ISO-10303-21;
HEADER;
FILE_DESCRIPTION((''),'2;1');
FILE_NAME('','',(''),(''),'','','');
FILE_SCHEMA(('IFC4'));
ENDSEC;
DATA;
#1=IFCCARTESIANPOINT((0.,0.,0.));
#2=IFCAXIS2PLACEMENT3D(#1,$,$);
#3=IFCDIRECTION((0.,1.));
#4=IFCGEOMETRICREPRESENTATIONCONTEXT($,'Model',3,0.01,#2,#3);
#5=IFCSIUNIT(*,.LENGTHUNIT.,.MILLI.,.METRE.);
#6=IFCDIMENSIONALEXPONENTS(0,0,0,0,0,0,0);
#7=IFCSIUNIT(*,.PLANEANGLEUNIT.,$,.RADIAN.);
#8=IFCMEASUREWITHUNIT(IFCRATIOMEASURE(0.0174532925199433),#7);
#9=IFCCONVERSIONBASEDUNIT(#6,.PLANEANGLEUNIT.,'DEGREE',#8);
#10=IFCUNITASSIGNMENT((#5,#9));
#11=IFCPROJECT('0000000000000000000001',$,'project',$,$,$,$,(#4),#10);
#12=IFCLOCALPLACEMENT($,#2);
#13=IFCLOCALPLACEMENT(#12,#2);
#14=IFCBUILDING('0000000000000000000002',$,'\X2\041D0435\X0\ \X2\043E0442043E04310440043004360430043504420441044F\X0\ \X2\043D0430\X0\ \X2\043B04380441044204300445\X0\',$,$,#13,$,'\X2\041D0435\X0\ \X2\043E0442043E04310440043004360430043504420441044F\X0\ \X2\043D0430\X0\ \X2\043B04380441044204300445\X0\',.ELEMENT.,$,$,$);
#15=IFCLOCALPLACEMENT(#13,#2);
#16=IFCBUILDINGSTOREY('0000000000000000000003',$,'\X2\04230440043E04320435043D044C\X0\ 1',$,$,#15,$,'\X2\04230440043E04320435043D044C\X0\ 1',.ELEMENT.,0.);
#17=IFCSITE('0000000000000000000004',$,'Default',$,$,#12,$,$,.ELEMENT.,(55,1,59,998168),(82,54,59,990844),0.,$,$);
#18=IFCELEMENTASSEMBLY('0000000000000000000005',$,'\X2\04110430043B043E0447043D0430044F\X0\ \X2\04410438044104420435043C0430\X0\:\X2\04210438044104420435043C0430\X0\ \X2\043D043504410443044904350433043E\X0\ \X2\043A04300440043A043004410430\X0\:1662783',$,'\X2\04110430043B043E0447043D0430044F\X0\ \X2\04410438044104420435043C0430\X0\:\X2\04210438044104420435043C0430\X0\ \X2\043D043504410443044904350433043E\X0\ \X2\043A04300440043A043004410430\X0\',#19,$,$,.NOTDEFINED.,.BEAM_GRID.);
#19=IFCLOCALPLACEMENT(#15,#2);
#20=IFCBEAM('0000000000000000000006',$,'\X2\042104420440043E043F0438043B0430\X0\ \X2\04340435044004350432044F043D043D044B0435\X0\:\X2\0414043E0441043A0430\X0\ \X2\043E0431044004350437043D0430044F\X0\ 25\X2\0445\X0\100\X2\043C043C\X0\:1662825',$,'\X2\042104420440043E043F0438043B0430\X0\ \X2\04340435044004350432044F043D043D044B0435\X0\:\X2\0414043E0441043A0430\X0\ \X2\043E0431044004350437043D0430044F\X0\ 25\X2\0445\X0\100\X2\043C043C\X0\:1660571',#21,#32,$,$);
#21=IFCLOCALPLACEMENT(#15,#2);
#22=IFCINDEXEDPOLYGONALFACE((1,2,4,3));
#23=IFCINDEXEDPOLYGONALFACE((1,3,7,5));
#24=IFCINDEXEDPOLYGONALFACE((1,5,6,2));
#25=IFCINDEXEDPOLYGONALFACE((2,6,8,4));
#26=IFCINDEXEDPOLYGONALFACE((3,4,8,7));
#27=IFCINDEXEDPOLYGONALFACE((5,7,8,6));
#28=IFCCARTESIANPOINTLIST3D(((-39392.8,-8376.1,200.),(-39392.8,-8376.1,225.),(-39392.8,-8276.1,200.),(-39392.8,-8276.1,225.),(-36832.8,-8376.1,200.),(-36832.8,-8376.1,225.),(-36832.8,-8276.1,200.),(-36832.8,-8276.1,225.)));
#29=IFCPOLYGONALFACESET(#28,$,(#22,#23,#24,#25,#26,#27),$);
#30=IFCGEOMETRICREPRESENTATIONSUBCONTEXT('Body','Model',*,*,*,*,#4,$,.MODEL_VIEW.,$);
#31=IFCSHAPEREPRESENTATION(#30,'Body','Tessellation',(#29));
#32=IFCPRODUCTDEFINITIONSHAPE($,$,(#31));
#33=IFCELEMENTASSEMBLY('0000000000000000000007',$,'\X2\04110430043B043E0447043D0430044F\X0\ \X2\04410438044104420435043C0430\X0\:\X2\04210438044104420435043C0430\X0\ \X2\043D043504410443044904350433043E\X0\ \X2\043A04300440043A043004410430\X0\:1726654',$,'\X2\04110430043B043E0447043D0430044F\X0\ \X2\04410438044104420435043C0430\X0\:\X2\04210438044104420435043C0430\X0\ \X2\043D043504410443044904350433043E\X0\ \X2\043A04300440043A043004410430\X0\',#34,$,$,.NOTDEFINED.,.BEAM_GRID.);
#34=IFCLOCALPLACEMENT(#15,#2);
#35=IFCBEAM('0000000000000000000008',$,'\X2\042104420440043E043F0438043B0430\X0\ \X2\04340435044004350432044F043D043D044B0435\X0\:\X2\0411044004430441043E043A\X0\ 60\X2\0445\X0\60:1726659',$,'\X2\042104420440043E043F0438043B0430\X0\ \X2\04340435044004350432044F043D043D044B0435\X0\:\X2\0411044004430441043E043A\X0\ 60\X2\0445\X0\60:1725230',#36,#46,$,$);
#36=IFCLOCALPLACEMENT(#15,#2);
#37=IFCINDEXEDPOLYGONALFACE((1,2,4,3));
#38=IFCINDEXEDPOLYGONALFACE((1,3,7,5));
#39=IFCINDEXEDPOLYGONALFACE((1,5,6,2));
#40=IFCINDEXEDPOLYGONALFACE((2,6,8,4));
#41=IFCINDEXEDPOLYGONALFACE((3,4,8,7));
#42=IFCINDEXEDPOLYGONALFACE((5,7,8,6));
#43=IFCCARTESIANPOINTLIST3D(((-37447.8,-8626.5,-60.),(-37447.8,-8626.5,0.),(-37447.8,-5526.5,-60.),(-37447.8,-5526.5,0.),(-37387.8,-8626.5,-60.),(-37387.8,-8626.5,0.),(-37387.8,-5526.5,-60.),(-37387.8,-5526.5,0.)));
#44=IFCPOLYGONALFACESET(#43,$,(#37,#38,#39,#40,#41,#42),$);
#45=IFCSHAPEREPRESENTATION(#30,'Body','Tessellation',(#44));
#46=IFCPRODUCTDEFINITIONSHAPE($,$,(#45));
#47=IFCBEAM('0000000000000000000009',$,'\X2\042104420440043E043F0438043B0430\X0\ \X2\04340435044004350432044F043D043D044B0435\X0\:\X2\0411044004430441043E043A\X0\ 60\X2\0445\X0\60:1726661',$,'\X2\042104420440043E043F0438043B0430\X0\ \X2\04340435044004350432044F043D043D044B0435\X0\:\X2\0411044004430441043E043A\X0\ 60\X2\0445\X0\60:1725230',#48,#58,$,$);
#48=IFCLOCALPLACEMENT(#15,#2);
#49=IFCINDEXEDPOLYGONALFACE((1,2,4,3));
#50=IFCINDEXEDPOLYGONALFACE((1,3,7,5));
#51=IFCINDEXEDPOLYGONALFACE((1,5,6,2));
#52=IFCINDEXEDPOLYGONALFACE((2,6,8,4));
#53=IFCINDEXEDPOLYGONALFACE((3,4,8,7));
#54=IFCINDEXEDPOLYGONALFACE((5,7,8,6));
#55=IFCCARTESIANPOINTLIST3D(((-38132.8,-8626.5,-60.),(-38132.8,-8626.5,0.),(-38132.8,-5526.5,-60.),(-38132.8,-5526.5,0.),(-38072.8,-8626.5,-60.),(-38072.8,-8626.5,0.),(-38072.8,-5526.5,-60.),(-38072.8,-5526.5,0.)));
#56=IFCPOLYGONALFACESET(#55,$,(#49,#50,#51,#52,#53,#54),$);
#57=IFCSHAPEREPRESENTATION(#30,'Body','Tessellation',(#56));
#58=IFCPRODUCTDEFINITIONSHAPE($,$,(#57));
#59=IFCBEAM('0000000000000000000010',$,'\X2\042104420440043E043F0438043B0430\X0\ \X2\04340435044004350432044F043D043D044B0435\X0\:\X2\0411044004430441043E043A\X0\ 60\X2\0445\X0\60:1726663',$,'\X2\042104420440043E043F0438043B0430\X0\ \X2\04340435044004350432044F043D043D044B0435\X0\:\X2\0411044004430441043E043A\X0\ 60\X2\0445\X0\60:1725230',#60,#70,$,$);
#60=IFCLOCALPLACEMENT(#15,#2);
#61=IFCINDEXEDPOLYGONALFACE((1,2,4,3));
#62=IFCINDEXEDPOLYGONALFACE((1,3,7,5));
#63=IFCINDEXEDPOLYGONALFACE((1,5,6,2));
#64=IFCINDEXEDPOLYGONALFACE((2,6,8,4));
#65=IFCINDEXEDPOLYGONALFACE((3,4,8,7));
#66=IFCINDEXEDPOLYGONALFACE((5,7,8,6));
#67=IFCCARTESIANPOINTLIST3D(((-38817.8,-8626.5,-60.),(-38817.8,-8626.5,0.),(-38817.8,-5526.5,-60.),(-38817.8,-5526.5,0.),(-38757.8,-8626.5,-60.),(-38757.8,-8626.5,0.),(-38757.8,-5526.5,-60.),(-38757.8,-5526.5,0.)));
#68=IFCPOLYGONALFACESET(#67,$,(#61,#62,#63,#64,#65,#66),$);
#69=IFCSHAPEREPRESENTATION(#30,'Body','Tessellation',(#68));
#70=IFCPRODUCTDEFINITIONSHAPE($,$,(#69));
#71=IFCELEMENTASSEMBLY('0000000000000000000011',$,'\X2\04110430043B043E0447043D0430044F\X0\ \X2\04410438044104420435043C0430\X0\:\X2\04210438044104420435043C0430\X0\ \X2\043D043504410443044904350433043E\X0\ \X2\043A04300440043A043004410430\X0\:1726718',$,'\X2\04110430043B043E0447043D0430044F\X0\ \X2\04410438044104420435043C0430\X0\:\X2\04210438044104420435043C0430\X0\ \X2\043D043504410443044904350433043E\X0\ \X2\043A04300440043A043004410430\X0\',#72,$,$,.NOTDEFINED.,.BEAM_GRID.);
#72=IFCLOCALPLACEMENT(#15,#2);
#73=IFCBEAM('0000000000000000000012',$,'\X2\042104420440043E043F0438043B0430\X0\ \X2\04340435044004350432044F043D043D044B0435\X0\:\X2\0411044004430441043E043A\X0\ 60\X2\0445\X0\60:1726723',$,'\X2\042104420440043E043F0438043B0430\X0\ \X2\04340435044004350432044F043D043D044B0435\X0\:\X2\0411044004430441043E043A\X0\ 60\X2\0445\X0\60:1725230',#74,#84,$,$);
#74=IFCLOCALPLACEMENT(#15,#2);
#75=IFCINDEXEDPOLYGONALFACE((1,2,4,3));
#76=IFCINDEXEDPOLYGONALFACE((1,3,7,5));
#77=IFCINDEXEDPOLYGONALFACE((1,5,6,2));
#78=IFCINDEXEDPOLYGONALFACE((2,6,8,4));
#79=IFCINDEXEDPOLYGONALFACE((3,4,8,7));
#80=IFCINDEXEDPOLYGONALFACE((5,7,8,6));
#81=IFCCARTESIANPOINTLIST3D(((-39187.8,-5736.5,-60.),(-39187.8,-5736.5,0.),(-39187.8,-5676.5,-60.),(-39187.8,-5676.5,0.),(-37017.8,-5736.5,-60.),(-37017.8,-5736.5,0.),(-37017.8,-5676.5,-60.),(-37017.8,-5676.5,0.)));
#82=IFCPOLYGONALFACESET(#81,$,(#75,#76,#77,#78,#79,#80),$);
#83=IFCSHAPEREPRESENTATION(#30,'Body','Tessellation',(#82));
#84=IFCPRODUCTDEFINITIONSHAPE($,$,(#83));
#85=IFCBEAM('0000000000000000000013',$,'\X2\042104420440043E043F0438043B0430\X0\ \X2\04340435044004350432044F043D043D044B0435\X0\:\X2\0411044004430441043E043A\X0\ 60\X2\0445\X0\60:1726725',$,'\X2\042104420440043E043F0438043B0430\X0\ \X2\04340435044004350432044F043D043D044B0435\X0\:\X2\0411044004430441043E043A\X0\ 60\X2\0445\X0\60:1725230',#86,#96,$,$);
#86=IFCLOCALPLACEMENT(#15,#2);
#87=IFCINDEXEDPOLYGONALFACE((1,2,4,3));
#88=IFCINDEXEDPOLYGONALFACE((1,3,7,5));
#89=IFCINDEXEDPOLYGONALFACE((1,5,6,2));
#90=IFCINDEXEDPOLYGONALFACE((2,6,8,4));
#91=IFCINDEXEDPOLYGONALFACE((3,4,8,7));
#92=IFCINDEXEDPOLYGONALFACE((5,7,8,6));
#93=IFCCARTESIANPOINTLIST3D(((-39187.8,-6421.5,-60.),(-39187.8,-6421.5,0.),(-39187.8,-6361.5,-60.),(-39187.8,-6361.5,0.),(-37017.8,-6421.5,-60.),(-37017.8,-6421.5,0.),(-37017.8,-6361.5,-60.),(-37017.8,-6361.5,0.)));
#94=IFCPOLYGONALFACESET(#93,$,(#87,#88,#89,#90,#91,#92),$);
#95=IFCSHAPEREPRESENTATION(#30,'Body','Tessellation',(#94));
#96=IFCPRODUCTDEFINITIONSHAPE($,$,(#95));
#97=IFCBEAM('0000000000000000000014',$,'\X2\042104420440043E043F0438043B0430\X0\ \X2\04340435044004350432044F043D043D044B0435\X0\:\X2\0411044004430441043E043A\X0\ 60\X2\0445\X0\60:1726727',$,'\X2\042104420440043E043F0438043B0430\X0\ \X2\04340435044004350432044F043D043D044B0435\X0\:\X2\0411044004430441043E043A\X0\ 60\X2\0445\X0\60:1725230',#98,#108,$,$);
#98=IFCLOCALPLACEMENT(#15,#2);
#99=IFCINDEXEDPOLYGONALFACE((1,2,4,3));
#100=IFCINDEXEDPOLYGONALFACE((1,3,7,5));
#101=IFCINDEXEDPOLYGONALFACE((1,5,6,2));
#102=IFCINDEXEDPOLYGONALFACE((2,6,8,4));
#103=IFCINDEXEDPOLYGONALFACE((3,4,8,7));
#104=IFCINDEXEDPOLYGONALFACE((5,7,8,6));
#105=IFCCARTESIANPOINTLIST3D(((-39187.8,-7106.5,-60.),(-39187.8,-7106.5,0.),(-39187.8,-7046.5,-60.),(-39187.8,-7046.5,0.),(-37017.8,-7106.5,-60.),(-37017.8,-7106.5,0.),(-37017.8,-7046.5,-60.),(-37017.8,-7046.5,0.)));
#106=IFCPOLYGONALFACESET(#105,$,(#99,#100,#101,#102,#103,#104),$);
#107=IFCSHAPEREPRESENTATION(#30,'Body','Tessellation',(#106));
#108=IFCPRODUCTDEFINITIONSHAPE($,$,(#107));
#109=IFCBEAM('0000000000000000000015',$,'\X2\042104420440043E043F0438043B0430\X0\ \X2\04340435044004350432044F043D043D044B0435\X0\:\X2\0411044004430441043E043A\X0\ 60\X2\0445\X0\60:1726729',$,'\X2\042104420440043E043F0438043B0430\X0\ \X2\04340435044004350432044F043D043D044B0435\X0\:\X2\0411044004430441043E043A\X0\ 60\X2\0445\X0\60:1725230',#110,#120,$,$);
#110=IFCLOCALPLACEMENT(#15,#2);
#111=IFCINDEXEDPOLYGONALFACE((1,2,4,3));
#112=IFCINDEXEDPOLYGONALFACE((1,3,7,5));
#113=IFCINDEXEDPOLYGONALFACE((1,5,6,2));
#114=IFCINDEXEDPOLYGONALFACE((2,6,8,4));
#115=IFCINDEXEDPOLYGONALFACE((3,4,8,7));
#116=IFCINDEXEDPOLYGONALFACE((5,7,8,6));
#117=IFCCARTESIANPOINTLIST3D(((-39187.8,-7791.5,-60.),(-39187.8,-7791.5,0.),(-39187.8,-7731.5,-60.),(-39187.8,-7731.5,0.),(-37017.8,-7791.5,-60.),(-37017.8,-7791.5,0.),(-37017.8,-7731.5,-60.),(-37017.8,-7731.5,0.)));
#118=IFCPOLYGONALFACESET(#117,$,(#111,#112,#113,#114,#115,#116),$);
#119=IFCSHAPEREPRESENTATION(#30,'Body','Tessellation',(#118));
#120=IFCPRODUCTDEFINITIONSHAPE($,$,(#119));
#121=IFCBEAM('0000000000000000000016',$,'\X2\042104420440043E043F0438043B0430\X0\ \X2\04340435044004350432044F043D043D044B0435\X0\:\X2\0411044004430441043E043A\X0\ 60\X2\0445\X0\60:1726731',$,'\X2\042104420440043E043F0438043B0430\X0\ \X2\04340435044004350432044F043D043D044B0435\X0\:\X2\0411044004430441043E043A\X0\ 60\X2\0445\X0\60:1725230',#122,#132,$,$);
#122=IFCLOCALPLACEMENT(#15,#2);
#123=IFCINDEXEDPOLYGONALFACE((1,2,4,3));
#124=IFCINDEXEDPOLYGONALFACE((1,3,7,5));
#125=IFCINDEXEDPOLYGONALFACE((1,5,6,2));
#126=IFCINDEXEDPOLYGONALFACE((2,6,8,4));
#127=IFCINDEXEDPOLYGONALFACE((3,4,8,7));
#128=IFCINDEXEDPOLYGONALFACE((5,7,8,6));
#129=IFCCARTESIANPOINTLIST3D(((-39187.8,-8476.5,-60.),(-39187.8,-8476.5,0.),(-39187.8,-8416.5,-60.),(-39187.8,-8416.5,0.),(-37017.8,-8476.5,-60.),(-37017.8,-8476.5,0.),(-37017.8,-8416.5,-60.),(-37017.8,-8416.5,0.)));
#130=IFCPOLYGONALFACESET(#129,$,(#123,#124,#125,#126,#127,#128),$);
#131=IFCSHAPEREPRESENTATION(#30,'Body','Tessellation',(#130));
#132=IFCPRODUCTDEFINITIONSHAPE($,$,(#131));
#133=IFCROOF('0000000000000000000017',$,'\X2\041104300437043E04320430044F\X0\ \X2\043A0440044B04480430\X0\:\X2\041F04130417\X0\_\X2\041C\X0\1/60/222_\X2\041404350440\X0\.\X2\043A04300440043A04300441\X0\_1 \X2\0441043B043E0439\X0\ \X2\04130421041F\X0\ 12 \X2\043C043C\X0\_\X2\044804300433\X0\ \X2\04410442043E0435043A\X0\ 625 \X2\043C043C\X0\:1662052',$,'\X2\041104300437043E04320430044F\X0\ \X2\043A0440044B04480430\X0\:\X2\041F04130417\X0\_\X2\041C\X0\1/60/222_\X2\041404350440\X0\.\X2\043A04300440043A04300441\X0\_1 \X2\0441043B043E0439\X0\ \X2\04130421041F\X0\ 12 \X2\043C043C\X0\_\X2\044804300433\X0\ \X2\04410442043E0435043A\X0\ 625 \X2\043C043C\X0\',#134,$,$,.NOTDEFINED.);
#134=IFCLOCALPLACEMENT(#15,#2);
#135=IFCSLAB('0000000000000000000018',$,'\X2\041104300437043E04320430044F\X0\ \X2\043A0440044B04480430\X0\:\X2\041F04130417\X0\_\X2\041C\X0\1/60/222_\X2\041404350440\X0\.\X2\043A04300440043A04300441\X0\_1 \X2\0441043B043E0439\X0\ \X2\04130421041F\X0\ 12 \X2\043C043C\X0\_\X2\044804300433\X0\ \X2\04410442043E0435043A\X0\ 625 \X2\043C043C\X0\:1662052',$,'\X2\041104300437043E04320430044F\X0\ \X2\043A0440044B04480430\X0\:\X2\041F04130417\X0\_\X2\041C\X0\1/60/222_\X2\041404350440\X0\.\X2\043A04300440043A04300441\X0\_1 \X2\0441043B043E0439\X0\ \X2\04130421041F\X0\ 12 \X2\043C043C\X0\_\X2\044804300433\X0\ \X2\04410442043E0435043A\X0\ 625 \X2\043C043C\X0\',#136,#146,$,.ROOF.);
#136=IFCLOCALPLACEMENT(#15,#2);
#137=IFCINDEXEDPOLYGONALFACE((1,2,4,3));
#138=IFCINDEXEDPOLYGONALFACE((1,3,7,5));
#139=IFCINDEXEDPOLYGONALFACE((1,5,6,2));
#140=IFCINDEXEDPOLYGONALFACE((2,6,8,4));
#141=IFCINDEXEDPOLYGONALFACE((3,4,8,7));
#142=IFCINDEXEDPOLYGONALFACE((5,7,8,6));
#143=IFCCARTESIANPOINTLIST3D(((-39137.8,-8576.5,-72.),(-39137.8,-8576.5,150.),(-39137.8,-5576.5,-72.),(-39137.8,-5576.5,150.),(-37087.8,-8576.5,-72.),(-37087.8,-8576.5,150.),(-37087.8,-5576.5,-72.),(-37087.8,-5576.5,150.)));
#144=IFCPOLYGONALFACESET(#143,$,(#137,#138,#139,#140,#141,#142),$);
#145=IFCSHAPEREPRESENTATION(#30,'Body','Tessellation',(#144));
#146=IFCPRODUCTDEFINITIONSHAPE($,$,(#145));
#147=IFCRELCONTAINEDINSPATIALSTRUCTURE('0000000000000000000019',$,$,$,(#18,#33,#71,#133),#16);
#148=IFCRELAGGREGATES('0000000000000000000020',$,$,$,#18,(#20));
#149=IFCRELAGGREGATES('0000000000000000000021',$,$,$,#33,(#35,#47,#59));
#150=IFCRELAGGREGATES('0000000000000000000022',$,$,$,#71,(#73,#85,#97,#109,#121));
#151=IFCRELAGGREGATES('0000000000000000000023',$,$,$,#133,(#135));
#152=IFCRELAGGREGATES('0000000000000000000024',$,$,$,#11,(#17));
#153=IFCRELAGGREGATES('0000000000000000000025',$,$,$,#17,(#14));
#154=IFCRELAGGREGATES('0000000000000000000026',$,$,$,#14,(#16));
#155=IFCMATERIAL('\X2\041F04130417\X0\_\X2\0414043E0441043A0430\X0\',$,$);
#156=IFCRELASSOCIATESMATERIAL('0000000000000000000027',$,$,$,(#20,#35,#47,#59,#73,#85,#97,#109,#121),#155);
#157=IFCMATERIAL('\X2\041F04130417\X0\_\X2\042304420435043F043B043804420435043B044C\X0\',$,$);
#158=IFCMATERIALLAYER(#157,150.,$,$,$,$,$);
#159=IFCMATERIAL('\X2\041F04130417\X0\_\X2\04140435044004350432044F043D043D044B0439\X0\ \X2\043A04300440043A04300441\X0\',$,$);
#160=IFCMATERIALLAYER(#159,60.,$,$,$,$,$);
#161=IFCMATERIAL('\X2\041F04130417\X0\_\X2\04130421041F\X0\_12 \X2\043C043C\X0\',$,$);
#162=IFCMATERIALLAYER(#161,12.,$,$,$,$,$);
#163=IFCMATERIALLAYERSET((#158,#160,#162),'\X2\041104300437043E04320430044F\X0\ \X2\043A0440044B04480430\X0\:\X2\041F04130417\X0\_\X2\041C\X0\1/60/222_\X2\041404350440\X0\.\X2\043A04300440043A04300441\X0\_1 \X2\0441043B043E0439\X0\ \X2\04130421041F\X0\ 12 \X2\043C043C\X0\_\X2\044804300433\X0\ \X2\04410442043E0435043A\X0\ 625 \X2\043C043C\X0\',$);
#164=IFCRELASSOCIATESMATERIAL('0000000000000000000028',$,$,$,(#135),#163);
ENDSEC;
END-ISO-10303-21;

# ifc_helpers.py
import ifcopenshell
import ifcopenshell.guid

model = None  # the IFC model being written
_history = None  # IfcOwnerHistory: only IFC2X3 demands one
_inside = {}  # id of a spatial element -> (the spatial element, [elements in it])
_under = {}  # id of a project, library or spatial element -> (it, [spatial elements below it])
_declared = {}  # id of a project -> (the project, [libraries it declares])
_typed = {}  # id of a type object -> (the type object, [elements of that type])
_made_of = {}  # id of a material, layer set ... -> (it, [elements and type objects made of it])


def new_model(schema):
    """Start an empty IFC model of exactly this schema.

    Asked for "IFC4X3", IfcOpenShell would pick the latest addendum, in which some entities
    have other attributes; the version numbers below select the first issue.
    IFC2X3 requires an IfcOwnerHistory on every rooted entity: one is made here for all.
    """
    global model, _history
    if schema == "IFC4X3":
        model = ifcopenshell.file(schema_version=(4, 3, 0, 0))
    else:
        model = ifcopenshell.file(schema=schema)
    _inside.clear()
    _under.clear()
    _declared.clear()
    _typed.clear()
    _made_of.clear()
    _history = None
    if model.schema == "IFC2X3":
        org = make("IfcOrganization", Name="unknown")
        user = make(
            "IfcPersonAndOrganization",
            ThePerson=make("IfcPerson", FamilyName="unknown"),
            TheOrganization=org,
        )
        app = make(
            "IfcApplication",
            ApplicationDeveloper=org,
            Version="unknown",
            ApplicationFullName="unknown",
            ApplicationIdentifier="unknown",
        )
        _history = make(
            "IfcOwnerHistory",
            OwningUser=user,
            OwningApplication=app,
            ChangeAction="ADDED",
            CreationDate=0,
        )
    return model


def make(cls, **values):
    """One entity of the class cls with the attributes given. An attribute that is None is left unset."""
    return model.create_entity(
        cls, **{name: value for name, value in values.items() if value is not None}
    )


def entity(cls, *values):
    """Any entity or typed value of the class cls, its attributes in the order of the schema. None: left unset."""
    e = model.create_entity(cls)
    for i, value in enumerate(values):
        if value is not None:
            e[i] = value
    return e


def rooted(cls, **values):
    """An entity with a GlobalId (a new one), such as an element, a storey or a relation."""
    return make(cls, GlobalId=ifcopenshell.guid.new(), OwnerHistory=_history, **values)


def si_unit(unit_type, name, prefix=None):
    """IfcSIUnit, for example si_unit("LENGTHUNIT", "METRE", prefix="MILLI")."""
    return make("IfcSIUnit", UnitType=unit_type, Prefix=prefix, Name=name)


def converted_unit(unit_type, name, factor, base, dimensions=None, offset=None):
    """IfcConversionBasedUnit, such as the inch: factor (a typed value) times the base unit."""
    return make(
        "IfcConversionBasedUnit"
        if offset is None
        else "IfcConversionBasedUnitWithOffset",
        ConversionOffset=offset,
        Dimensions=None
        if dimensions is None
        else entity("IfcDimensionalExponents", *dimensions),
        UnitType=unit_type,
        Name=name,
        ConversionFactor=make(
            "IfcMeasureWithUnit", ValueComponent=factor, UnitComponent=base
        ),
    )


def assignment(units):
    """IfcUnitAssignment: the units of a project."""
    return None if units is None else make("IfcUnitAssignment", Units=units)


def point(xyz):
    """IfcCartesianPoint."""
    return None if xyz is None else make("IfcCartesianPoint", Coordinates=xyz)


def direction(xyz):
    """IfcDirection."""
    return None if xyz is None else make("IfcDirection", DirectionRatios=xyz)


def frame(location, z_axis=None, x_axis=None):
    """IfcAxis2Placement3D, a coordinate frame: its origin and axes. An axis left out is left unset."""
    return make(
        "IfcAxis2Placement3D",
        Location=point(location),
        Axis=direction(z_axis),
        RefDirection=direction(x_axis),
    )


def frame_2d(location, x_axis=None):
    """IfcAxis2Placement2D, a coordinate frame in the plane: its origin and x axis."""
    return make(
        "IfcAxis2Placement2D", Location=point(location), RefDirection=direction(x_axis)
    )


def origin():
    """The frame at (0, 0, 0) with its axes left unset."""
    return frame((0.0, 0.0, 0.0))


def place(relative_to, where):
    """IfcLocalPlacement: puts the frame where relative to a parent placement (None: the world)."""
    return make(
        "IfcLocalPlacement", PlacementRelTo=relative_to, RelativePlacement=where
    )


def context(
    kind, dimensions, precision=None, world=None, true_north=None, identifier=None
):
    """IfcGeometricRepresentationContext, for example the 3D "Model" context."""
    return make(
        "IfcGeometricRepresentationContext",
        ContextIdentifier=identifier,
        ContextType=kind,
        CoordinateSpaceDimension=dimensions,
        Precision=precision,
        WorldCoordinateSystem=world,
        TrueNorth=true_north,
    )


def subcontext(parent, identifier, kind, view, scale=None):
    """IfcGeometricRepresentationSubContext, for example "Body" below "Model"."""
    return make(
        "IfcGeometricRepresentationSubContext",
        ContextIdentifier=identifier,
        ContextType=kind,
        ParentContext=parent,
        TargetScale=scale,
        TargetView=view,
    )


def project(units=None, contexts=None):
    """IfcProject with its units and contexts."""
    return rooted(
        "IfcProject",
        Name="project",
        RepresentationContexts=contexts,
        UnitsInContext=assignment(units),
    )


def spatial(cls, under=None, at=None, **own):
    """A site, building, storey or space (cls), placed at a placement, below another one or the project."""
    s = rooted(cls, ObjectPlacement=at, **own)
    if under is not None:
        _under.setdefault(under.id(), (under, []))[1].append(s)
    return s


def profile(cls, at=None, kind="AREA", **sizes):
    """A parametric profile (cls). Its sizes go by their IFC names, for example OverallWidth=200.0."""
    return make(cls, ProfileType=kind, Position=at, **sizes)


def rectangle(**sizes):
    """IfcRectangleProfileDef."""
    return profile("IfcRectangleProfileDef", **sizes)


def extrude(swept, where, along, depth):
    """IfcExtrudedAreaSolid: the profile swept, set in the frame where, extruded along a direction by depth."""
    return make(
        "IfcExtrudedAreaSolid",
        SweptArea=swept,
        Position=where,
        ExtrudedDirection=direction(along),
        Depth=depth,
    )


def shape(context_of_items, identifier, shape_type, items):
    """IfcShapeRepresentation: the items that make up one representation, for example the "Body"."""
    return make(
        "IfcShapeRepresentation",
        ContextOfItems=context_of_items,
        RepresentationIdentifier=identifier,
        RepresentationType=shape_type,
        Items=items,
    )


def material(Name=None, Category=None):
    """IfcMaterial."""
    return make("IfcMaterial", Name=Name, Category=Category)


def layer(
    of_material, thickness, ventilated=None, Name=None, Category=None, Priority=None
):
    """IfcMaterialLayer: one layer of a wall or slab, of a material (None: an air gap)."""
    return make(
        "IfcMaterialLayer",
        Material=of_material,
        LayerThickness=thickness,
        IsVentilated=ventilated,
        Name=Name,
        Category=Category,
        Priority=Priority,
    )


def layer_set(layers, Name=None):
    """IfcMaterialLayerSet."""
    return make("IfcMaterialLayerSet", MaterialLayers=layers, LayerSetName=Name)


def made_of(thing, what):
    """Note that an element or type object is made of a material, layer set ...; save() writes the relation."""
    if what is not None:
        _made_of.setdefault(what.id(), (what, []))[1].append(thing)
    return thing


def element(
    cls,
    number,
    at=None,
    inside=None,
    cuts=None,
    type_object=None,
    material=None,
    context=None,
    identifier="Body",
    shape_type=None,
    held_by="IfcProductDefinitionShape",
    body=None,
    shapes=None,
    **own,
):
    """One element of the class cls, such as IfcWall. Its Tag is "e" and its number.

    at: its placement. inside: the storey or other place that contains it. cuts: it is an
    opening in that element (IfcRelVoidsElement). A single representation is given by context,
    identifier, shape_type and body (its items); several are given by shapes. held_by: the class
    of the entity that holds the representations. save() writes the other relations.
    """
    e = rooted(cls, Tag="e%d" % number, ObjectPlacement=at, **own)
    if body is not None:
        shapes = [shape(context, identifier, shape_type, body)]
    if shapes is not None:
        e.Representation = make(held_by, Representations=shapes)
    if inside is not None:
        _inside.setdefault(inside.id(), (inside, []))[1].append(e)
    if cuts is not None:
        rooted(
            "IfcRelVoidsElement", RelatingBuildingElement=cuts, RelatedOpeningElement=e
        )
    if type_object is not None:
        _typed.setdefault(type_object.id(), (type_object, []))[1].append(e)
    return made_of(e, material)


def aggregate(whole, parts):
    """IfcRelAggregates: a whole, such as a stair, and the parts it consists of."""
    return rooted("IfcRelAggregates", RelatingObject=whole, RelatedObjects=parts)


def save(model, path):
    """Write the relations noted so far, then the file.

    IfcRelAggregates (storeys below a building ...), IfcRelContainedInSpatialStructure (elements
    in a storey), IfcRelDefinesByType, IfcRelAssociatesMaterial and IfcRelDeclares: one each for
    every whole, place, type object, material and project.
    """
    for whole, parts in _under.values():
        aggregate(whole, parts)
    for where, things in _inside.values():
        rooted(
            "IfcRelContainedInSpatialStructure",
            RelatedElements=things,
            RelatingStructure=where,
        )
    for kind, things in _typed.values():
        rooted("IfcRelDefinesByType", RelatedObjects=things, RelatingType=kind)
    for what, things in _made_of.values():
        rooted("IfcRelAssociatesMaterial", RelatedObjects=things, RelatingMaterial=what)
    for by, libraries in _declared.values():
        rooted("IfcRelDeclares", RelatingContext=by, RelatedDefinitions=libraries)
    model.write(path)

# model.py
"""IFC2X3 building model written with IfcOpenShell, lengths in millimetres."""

from ifc_helpers import new_model, entity, si_unit, converted_unit, direction, frame, frame_2d, origin, place, context, subcontext, project, spatial, rectangle, extrude, material, layer, layer_set, element, aggregate, save


model = new_model("IFC2X3")

# Units and contexts
model_context = context("Model", 3, precision=0.01, world=origin(), true_north=direction((0.0, 1.0)))
body_context = subcontext(model_context, "Body", "Model", "MODEL_VIEW")
ifc_project = project(units=[si_unit("LENGTHUNIT", "METRE", prefix="MILLI"), converted_unit("PLANEANGLEUNIT", "DEGREE", entity("IfcRatioMeasure", 0.0174532925199433), si_unit("PLANEANGLEUNIT", "RADIAN"), dimensions=[0, 0, 0, 0, 0, 0, 0])], contexts=[model_context])

# Site, building, storey
site_placement = place(None, origin())
site = spatial("IfcSite", under=ifc_project, at=site_placement, Name="Default", CompositionType="ELEMENT", RefLatitude=(55, 1, 59, 998168), RefLongitude=(82, 54, 59, 990844), RefElevation=0.0)
building_placement = place(site_placement, origin())
building = spatial("IfcBuilding", under=site, at=building_placement, Name="Не отображается на листах", LongName="Не отображается на листах", CompositionType="ELEMENT")
storey_placement = place(building_placement, frame((0.0, 0.0, 0.0)))
storey = spatial("IfcBuildingStorey", under=building, at=storey_placement, Name="Уровень 1", LongName="Уровень 1", CompositionType="ELEMENT", Elevation=0.0)

# Element assemblies, beams
ifc_material_1 = material(Name="ПГЗ_Доска")
assembly_1_placement = place(storey_placement, origin())
assembly_1 = element("IfcElementAssembly", 1, at=assembly_1_placement, inside=storey, Name="Балочная система:Система несущего каркаса:1662783", ObjectType="Балочная система:Система несущего каркаса", AssemblyPlace="NOTDEFINED", PredefinedType="BEAM_GRID")
beam_1_placement = place(assembly_1_placement, frame((-39392.8, -8326.1, 0.0)))
beam_1 = element("IfcBeam", 2, at=beam_1_placement, material=ifc_material_1, Name="Стропила деревянные:Доска обрезная 25х100мм:1662825", ObjectType="Стропила деревянные:Доска обрезная 25х100мм:1660571", context=body_context, shape_type="SweptSolid", body=[
    extrude(rectangle(XDim=25.0, YDim=100.0, at=frame_2d((0.0, 0.0), x_axis=(1.0, 0.0))), frame((0.0, 0.0, 212.5), z_axis=(1.0, 0.0, 0.0), x_axis=(0.0, 0.0, -1.0)), (0.0, 0.0, 1.0), 2560.0),
])
aggregate(assembly_1, [beam_1])
assembly_2_placement = place(storey_placement, origin())
assembly_2 = element("IfcElementAssembly", 3, at=assembly_2_placement, inside=storey, Name="Балочная система:Система несущего каркаса:1726654", ObjectType="Балочная система:Система несущего каркаса", AssemblyPlace="NOTDEFINED", PredefinedType="BEAM_GRID")
beam_2_placement = place(assembly_2_placement, frame((-37417.8, -5526.5, 0.0), z_axis=(0.0, 0.0, 1.0), x_axis=(0.0, -1.0, 0.0)))
beam_2 = element("IfcBeam", 4, at=beam_2_placement, material=ifc_material_1, Name="Стропила деревянные:Брусок 60х60:1726659", ObjectType="Стропила деревянные:Брусок 60х60:1725230", context=body_context, shape_type="SweptSolid", body=[
    extrude(rectangle(XDim=60.0, YDim=60.0, at=frame_2d((0.0, 0.0), x_axis=(1.0, 0.0))), frame((0.0, 0.0, -30.0), z_axis=(1.0, 0.0, 0.0), x_axis=(0.0, 0.0, -1.0)), (0.0, 0.0, 1.0), 3100.0),
])
beam_3_placement = place(assembly_2_placement, frame((-38102.8, -5526.5, 0.0), z_axis=(0.0, 0.0, 1.0), x_axis=(0.0, -1.0, 0.0)))
beam_3 = element("IfcBeam", 5, at=beam_3_placement, material=ifc_material_1, Name="Стропила деревянные:Брусок 60х60:1726661", ObjectType="Стропила деревянные:Брусок 60х60:1725230", context=body_context, shape_type="SweptSolid", body=[
    extrude(rectangle(XDim=60.0, YDim=60.0, at=frame_2d((0.0, 0.0), x_axis=(1.0, 0.0))), frame((0.0, 0.0, -30.0), z_axis=(1.0, 0.0, 0.0), x_axis=(0.0, 0.0, -1.0)), (0.0, 0.0, 1.0), 3100.0),
])
beam_4_placement = place(assembly_2_placement, frame((-38787.8, -5526.5, 0.0), z_axis=(0.0, 0.0, 1.0), x_axis=(0.0, -1.0, 0.0)))
beam_4 = element("IfcBeam", 6, at=beam_4_placement, material=ifc_material_1, Name="Стропила деревянные:Брусок 60х60:1726663", ObjectType="Стропила деревянные:Брусок 60х60:1725230", context=body_context, shape_type="SweptSolid", body=[
    extrude(rectangle(XDim=60.0, YDim=60.0, at=frame_2d((0.0, 0.0), x_axis=(1.0, 0.0))), frame((0.0, 0.0, -30.0), z_axis=(1.0, 0.0, 0.0), x_axis=(0.0, 0.0, -1.0)), (0.0, 0.0, 1.0), 3100.0),
])
aggregate(assembly_2, [beam_2, beam_3, beam_4])
assembly_3_placement = place(storey_placement, origin())
assembly_3 = element("IfcElementAssembly", 7, at=assembly_3_placement, inside=storey, Name="Балочная система:Система несущего каркаса:1726718", ObjectType="Балочная система:Система несущего каркаса", AssemblyPlace="NOTDEFINED", PredefinedType="BEAM_GRID")
beam_5_placement = place(assembly_3_placement, frame((-39187.8, -5706.5, 0.0)))
beam_5 = element("IfcBeam", 8, at=beam_5_placement, material=ifc_material_1, Name="Стропила деревянные:Брусок 60х60:1726723", ObjectType="Стропила деревянные:Брусок 60х60:1725230", context=body_context, shape_type="SweptSolid", body=[
    extrude(rectangle(XDim=60.0, YDim=60.0, at=frame_2d((0.0, 0.0), x_axis=(1.0, 0.0))), frame((0.0, 0.0, -30.0), z_axis=(1.0, 0.0, 0.0), x_axis=(0.0, 0.0, -1.0)), (0.0, 0.0, 1.0), 2170.0),
])
beam_6_placement = place(assembly_3_placement, frame((-39187.8, -6391.5, 0.0)))
beam_6 = element("IfcBeam", 9, at=beam_6_placement, material=ifc_material_1, Name="Стропила деревянные:Брусок 60х60:1726725", ObjectType="Стропила деревянные:Брусок 60х60:1725230", context=body_context, shape_type="SweptSolid", body=[
    extrude(rectangle(XDim=60.0, YDim=60.0, at=frame_2d((0.0, 0.0), x_axis=(1.0, 0.0))), frame((0.0, 0.0, -30.0), z_axis=(1.0, 0.0, 0.0), x_axis=(0.0, 0.0, -1.0)), (0.0, 0.0, 1.0), 2170.0),
])
beam_7_placement = place(assembly_3_placement, frame((-39187.8, -7076.5, 0.0)))
beam_7 = element("IfcBeam", 10, at=beam_7_placement, material=ifc_material_1, Name="Стропила деревянные:Брусок 60х60:1726727", ObjectType="Стропила деревянные:Брусок 60х60:1725230", context=body_context, shape_type="SweptSolid", body=[
    extrude(rectangle(XDim=60.0, YDim=60.0, at=frame_2d((0.0, 0.0), x_axis=(1.0, 0.0))), frame((0.0, 0.0, -30.0), z_axis=(1.0, 0.0, 0.0), x_axis=(0.0, 0.0, -1.0)), (0.0, 0.0, 1.0), 2170.0),
])
beam_8_placement = place(assembly_3_placement, frame((-39187.8, -7761.5, 0.0)))
beam_8 = element("IfcBeam", 11, at=beam_8_placement, material=ifc_material_1, Name="Стропила деревянные:Брусок 60х60:1726729", ObjectType="Стропила деревянные:Брусок 60х60:1725230", context=body_context, shape_type="SweptSolid", body=[
    extrude(rectangle(XDim=60.0, YDim=60.0, at=frame_2d((0.0, 0.0), x_axis=(1.0, 0.0))), frame((0.0, 0.0, -30.0), z_axis=(1.0, 0.0, 0.0), x_axis=(0.0, 0.0, -1.0)), (0.0, 0.0, 1.0), 2170.0),
])
beam_9_placement = place(assembly_3_placement, frame((-39187.8, -8446.5, 0.0)))
beam_9 = element("IfcBeam", 12, at=beam_9_placement, material=ifc_material_1, Name="Стропила деревянные:Брусок 60х60:1726731", ObjectType="Стропила деревянные:Брусок 60х60:1725230", context=body_context, shape_type="SweptSolid", body=[
    extrude(rectangle(XDim=60.0, YDim=60.0, at=frame_2d((0.0, 0.0), x_axis=(1.0, 0.0))), frame((0.0, 0.0, -30.0), z_axis=(1.0, 0.0, 0.0), x_axis=(0.0, 0.0, -1.0)), (0.0, 0.0, 1.0), 2170.0),
])
aggregate(assembly_3, [beam_5, beam_6, beam_7, beam_8, beam_9])

# Roof, slab
roof_placement = place(storey_placement, frame((-39137.8, -8576.5, -72.0)))
roof = element("IfcRoof", 13, at=roof_placement, inside=storey, Name="Базовая крыша:ПГЗ_М1/60/222_Дер.каркас_1 слой ГСП 12 мм_шаг стоек 625 мм:1662052", ObjectType="Базовая крыша:ПГЗ_М1/60/222_Дер.каркас_1 слой ГСП 12 мм_шаг стоек 625 мм", ShapeType="NOTDEFINED")
ifc_material_2 = material(Name="ПГЗ_Утеплитель")
ifc_layer_1 = layer(ifc_material_2, 150.0)
ifc_material_3 = material(Name="ПГЗ_Деревянный каркас")
ifc_layer_2 = layer(ifc_material_3, 60.0)
ifc_material_4 = material(Name="ПГЗ_ГСП_12 мм")
ifc_layer_3 = layer(ifc_material_4, 12.0)
ifc_layer_set = layer_set([ifc_layer_1, ifc_layer_2, ifc_layer_3], Name="Базовая крыша:ПГЗ_М1/60/222_Дер.каркас_1 слой ГСП 12 мм_шаг стоек 625 мм")
slab_placement = place(roof_placement, origin())
slab = element("IfcSlab", 14, at=slab_placement, material=ifc_layer_set, Name="Базовая крыша:ПГЗ_М1/60/222_Дер.каркас_1 слой ГСП 12 мм_шаг стоек 625 мм:1662052", ObjectType="Базовая крыша:ПГЗ_М1/60/222_Дер.каркас_1 слой ГСП 12 мм_шаг стоек 625 мм", PredefinedType="ROOF", context=body_context, shape_type="SweptSolid", body=[
    extrude(rectangle(XDim=2050.0, YDim=3000.0, at=frame_2d((0.0, 0.0), x_axis=(1.0, 0.0))), frame((1025.0, 1500.0, 0.0)), (0.0, 0.0, 1.0), 222.0),
])
aggregate(roof, [slab])

save(model, "model.ifc")
